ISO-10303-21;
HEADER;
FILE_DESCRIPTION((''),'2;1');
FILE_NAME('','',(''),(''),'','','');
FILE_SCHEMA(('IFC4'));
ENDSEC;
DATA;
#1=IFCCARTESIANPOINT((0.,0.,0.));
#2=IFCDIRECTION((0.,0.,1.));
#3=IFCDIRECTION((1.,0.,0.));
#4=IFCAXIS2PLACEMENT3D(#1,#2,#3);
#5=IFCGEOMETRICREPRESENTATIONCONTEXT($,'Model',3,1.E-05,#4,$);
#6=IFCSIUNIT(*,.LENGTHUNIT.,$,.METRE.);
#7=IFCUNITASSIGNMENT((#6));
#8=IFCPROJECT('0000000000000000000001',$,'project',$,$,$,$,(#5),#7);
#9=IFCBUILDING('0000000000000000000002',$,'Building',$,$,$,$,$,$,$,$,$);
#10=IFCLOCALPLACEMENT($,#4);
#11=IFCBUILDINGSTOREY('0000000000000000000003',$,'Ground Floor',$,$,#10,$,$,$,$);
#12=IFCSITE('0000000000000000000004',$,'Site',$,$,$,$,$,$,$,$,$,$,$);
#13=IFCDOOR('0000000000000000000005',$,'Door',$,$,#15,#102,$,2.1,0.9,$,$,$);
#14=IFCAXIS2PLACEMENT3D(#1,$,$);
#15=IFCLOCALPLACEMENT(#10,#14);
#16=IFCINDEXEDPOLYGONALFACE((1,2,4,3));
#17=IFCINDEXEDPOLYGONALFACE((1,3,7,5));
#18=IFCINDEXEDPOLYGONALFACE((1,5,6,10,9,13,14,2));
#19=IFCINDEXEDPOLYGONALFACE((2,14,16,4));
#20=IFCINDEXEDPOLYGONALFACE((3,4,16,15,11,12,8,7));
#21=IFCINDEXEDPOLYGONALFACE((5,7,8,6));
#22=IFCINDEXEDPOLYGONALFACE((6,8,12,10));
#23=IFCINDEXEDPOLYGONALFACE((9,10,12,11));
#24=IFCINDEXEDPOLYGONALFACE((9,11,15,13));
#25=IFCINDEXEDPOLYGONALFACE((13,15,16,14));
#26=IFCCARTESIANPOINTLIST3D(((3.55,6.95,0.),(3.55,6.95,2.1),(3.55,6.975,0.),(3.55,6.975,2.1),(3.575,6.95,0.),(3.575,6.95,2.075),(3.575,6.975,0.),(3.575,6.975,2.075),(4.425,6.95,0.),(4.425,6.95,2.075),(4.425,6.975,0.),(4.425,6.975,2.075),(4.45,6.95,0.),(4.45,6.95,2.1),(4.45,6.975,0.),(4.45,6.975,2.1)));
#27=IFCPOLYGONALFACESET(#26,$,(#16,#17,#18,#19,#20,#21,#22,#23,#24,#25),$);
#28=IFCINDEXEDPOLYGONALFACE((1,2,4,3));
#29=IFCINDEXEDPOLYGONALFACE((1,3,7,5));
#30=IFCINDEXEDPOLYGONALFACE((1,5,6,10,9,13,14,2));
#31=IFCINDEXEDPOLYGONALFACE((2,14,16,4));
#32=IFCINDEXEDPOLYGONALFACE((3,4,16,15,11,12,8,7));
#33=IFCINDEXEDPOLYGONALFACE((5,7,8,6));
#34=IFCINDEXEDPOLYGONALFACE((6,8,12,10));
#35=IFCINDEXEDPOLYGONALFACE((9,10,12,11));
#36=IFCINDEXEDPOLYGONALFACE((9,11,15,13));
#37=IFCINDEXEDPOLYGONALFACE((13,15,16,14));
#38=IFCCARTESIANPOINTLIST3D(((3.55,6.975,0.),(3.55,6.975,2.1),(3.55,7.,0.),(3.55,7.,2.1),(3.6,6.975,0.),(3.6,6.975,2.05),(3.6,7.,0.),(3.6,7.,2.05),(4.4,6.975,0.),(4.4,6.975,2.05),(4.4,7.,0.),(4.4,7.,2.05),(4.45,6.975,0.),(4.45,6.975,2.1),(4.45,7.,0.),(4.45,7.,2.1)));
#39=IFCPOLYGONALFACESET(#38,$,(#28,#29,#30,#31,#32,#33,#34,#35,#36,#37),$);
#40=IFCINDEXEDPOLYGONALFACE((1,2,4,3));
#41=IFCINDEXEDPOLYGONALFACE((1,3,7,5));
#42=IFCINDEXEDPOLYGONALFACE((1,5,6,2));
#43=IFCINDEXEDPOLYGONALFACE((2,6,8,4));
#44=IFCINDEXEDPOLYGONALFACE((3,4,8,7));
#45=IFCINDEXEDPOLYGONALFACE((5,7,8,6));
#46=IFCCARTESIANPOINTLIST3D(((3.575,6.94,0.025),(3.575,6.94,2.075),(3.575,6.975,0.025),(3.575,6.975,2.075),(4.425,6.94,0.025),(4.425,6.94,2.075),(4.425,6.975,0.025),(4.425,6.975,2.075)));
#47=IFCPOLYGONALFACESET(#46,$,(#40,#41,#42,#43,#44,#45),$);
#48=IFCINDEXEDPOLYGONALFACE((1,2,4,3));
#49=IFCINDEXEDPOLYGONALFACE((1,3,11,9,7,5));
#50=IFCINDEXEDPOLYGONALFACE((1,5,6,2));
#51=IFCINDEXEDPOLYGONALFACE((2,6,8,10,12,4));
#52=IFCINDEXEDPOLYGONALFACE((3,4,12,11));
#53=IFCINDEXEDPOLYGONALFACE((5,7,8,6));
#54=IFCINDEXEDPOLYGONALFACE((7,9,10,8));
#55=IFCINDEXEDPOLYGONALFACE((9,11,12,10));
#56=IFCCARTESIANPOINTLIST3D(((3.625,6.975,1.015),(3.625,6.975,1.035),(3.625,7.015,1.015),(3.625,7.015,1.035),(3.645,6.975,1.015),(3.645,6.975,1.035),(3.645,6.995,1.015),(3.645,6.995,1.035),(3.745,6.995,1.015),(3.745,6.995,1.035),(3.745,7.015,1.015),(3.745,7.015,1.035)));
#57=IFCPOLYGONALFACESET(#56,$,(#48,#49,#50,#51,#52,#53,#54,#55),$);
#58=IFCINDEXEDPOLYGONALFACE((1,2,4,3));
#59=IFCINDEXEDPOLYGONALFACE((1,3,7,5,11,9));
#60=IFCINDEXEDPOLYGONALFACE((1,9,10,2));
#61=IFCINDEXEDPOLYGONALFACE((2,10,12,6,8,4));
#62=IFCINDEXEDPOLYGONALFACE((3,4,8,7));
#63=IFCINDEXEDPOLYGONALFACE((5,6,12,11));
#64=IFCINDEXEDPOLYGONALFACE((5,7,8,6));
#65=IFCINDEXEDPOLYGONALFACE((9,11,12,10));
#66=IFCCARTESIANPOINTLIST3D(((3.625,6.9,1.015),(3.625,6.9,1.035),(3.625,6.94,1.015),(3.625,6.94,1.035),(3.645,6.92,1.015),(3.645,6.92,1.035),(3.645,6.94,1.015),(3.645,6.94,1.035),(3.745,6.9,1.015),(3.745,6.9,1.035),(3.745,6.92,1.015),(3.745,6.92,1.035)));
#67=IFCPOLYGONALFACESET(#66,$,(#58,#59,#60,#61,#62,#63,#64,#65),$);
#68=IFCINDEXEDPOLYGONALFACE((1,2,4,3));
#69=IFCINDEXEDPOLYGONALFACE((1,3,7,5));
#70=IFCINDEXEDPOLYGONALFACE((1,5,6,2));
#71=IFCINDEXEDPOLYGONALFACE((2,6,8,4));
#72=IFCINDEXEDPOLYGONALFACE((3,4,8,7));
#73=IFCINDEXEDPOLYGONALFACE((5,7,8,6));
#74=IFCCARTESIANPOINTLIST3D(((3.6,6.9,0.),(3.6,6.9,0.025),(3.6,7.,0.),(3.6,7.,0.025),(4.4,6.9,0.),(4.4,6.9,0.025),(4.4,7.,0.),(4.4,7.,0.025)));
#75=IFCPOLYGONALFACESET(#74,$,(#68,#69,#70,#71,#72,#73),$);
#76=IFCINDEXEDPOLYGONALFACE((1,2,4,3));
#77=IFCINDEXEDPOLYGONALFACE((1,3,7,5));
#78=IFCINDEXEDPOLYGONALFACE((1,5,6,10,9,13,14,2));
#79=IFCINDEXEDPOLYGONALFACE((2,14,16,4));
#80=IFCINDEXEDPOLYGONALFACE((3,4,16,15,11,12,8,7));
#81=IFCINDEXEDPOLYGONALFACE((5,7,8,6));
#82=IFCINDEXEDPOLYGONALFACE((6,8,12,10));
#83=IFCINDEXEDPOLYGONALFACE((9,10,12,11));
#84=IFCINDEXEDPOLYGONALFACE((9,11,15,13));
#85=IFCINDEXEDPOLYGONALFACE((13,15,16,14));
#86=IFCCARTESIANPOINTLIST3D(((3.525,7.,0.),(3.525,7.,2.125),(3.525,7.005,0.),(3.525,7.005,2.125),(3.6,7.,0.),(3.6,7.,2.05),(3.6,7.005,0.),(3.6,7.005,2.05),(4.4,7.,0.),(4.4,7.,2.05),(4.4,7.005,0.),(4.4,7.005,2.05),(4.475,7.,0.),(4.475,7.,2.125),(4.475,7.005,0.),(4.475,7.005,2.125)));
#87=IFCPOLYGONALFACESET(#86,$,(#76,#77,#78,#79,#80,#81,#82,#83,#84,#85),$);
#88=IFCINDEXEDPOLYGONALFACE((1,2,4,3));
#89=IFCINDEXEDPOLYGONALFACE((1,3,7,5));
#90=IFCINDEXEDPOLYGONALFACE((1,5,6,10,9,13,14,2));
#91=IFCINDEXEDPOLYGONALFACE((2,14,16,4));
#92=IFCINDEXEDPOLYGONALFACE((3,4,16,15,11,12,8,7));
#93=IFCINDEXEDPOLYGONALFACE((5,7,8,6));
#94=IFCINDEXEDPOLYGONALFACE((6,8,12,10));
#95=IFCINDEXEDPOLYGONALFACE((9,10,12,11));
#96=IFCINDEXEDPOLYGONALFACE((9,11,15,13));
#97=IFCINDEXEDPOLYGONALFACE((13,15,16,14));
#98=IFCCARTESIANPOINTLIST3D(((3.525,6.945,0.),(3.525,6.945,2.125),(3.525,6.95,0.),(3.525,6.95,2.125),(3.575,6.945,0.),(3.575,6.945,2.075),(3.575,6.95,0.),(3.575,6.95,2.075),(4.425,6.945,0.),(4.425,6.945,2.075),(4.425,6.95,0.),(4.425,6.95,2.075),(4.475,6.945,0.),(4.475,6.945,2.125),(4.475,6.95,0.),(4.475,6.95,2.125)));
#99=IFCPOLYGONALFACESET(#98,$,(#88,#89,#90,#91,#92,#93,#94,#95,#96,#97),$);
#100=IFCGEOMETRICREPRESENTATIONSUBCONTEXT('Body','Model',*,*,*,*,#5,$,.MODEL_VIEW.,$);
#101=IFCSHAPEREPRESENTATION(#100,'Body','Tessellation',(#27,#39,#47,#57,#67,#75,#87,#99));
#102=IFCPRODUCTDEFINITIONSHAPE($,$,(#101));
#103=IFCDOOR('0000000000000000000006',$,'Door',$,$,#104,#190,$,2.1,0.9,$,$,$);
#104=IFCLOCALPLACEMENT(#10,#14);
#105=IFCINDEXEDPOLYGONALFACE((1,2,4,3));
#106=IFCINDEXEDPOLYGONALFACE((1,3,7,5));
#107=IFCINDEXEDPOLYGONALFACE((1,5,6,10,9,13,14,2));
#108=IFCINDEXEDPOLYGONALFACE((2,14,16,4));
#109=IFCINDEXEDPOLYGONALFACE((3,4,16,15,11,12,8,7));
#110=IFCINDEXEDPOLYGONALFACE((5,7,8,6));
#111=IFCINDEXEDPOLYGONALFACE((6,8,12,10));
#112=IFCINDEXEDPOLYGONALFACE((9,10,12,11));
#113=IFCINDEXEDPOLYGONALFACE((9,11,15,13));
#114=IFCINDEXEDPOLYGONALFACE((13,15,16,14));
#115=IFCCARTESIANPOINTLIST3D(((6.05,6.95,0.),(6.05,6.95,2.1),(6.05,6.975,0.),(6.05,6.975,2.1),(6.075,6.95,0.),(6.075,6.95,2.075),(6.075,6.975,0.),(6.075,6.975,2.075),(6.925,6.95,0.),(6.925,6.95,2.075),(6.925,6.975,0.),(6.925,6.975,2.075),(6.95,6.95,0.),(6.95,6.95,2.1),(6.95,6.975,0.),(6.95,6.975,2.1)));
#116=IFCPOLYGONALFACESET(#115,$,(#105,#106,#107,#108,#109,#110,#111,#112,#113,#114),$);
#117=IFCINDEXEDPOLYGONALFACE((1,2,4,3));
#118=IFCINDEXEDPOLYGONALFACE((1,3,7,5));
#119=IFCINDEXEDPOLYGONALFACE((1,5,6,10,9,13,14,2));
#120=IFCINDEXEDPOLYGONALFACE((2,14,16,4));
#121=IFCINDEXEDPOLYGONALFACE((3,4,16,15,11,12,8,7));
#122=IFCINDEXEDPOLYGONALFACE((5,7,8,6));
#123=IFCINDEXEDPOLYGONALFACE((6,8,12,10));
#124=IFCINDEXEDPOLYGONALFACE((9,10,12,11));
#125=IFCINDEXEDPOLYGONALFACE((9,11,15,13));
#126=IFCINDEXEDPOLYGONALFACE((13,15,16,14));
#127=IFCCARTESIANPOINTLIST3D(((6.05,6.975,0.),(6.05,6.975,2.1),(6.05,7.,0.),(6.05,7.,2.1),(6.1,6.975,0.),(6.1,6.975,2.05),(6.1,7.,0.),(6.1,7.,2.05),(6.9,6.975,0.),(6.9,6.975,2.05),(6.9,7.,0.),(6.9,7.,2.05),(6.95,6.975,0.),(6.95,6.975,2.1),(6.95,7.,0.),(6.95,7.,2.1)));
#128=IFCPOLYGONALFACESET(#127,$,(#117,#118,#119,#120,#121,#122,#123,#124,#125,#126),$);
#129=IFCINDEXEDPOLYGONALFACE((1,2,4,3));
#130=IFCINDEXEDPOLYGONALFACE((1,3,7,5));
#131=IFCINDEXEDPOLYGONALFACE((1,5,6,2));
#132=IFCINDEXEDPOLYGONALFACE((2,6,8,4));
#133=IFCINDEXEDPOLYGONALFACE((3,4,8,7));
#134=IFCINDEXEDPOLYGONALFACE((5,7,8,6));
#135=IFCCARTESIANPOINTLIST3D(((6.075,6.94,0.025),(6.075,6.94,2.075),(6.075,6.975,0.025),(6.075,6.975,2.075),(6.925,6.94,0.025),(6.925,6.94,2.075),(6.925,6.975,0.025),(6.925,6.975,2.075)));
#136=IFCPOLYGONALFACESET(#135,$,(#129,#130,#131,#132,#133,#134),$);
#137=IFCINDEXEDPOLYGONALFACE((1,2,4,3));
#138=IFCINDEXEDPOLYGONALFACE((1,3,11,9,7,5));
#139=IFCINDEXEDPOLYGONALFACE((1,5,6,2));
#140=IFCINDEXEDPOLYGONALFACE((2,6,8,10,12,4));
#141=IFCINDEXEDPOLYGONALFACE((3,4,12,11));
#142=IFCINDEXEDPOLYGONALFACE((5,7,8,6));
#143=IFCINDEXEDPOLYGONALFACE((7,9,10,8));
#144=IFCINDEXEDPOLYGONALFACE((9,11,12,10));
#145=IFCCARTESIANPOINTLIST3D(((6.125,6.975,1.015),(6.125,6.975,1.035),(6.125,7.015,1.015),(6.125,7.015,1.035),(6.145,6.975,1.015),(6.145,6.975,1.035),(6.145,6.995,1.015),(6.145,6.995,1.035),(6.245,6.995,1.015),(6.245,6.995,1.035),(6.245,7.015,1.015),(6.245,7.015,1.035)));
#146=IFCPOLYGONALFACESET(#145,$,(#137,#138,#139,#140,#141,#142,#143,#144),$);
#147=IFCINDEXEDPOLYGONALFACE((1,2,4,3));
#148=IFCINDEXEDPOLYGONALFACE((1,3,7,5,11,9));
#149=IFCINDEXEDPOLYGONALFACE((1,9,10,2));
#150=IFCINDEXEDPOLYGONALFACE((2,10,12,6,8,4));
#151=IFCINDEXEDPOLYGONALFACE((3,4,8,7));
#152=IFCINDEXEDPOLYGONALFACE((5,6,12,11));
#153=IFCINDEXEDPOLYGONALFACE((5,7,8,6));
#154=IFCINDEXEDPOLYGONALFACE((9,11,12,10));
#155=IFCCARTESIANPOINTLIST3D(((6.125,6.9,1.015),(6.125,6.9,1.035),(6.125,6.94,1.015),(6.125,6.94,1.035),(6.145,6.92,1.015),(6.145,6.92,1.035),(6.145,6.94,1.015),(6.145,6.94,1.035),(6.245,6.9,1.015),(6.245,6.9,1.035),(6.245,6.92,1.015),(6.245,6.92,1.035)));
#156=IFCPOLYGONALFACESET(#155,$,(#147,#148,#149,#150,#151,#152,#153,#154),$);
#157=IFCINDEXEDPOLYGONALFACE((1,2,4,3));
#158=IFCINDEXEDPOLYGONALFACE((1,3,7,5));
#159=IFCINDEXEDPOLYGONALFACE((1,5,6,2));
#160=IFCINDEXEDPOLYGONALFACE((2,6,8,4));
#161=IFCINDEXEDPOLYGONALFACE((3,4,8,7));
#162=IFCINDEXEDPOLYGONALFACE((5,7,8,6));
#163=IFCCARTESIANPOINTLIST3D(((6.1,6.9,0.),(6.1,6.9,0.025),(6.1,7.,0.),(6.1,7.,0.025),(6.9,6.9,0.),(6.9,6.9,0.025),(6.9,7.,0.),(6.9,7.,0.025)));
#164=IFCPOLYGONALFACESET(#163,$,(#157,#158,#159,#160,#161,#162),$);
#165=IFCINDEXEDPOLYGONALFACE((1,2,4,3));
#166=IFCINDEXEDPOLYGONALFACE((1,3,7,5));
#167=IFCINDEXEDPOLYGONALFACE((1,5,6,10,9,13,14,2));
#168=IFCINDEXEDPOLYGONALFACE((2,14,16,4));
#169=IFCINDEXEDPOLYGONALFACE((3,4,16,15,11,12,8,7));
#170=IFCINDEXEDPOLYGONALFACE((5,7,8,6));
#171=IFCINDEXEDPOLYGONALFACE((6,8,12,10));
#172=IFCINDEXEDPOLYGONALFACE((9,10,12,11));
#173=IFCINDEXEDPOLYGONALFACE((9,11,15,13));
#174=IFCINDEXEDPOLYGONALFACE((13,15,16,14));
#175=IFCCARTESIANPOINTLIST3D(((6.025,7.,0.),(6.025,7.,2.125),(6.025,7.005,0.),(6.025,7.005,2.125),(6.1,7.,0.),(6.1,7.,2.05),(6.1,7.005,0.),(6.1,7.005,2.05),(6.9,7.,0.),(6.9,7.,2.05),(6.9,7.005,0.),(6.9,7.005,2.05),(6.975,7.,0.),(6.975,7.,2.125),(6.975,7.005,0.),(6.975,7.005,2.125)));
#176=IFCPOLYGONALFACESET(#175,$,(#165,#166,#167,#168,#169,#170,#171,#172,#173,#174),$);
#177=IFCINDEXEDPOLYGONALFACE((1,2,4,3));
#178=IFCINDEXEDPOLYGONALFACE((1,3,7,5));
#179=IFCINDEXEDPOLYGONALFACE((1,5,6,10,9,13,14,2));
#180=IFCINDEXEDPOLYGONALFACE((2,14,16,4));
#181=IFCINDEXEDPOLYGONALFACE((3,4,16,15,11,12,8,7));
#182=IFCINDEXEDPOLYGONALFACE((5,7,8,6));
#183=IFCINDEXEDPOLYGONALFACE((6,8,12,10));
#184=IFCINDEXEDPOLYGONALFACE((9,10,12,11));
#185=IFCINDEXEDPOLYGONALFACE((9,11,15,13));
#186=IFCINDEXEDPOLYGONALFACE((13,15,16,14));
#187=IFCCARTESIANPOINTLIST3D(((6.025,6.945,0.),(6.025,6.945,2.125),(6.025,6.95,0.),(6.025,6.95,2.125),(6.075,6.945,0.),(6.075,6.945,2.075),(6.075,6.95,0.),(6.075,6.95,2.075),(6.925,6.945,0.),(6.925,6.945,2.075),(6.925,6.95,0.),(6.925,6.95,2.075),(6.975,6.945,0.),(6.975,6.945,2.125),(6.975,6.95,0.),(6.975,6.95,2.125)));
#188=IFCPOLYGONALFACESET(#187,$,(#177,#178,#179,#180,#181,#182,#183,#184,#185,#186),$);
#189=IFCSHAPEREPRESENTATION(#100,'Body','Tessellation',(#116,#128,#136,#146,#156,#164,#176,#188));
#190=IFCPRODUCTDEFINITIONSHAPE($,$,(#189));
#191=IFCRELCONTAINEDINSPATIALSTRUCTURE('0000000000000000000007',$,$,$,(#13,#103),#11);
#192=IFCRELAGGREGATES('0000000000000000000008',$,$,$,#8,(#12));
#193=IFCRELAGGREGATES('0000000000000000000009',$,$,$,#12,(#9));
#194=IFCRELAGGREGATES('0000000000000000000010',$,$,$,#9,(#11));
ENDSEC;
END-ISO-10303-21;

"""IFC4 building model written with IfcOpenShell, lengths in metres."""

from ifc_helpers import new_model, si_unit, frame, origin_with_axes, place, context, subcontext, project, spatial, line, indexed_curve, outline, extrude, element, save


model = new_model("IFC4")

# Units and contexts
model_context = context("Model", 3, precision=1e-05, world=origin_with_axes())
body_context = subcontext(model_context, "Body", "Model", "MODEL_VIEW")
ifc_project = project(units=[si_unit("LENGTHUNIT", "METRE")], contexts=[model_context])

# Site, building, storey
site = spatial("IfcSite", under=ifc_project, Name="Site")
building = spatial("IfcBuilding", under=site, Name="Building")
storey_placement = place(None, origin_with_axes())
storey = spatial("IfcBuildingStorey", under=building, at=storey_placement, Name="Ground Floor")

# Doors
door_1_placement = place(storey_placement, frame((4.45, 7.0, 0.0), z_axis=(0.0, 0.0, 1.0), x_axis=(-1.0, 0.0, 0.0)))
element("IfcDoor", 1, at=door_1_placement, inside=storey, Name="Door", OverallHeight=2.1, OverallWidth=0.9, context=body_context, shape_type="SweptSolid", body=[
    extrude(outline(indexed_curve([(0.0, 0.0), (0.0, 2.1), (0.9, 2.1), (0.9, 0.0), (0.875, 0.0), (0.875, 2.075), (0.025, 2.075), (0.025, 0.0)], segments=[line(1, 2, 3, 4, 5, 6, 7, 8, 1)])), frame((0.0, 0.025, 0.0), z_axis=(0.0, -1.0, 0.0), x_axis=(1.0, 0.0, 0.0)), (0.0, 0.0, -1.0), 0.025),
    extrude(outline(indexed_curve([(0.0, 0.0), (0.0, 2.1), (0.9, 2.1), (0.9, 0.0), (0.85, 0.0), (0.85, 2.05), (0.05, 2.05), (0.05, 0.0)], segments=[line(1, 2, 3, 4, 5, 6, 7, 8, 1)])), frame((0.0, 0.0, 0.0), z_axis=(0.0, -1.0, 0.0), x_axis=(1.0, 0.0, 0.0)), (0.0, 0.0, -1.0), 0.025),
    extrude(outline(indexed_curve([(0.0, 0.0), (0.85, 0.0), (0.85, 0.035), (0.0, 0.035)], segments=[line(1, 2, 3, 4, 1)])), frame((0.025, 0.025, 0.025), z_axis=(0.0, 0.0, 1.0), x_axis=(1.0, 0.0, 0.0)), (0.0, 0.0, 1.0), 2.05),
    extrude(outline(indexed_curve([(0.0, 0.0), (0.0, -0.04), (-0.12, -0.04), (-0.12, -0.02), (-0.02, -0.02), (-0.02, 0.0)], segments=[line(1, 2, 3, 4, 5, 6, 1)])), frame((0.825, 0.025, 1.015), z_axis=(0.0, 0.0, 1.0), x_axis=(1.0, 0.0, 0.0)), (0.0, 0.0, 1.0), 0.02),
    extrude(outline(indexed_curve([(0.0, 0.0), (0.0, 0.04), (-0.12, 0.04), (-0.12, 0.02), (-0.02, 0.02), (-0.02, 0.0)], segments=[line(1, 2, 3, 4, 5, 6, 1)])), frame((0.825, 0.06, 1.015), z_axis=(0.0, 0.0, 1.0), x_axis=(1.0, 0.0, 0.0)), (0.0, 0.0, 1.0), 0.02),
    extrude(outline(indexed_curve([(0.0, 0.0), (0.8, 0.0), (0.8, 0.1), (0.0, 0.1)], segments=[line(1, 2, 3, 4, 1)])), frame((0.05, 0.0, 0.0), z_axis=(0.0, 0.0, 1.0), x_axis=(1.0, 0.0, 0.0)), (0.0, 0.0, 1.0), 0.025),
    extrude(outline(indexed_curve([(0.0, 0.0), (0.0, 2.125), (0.95, 2.125), (0.95, 0.0), (0.875, 0.0), (0.875, 2.05), (0.075, 2.05), (0.075, 0.0)], segments=[line(1, 2, 3, 4, 5, 6, 7, 8, 1)])), frame((-0.025, -0.005, 0.0), z_axis=(0.0, -1.0, 0.0), x_axis=(1.0, 0.0, 0.0)), (0.0, 0.0, -1.0), 0.005),
    extrude(outline(indexed_curve([(0.0, 0.0), (0.0, 2.125), (0.95, 2.125), (0.95, 0.0), (0.9, 0.0), (0.9, 2.075), (0.05, 2.075), (0.05, 0.0)], segments=[line(1, 2, 3, 4, 5, 6, 7, 8, 1)])), frame((-0.025, 0.05, 0.0), z_axis=(0.0, -1.0, 0.0), x_axis=(1.0, 0.0, 0.0)), (0.0, 0.0, -1.0), 0.005),
])
door_2_placement = place(storey_placement, frame((6.95, 7.0, 0.0), z_axis=(0.0, 0.0, 1.0), x_axis=(-1.0, 0.0, 0.0)))
element("IfcDoor", 2, at=door_2_placement, inside=storey, Name="Door", OverallHeight=2.1, OverallWidth=0.9, context=body_context, shape_type="SweptSolid", body=[
    extrude(outline(indexed_curve([(0.0, 0.0), (0.0, 2.1), (0.9, 2.1), (0.9, 0.0), (0.875, 0.0), (0.875, 2.075), (0.025, 2.075), (0.025, 0.0)], segments=[line(1, 2, 3, 4, 5, 6, 7, 8, 1)])), frame((0.0, 0.025, 0.0), z_axis=(0.0, -1.0, 0.0), x_axis=(1.0, 0.0, 0.0)), (0.0, 0.0, -1.0), 0.025),
    extrude(outline(indexed_curve([(0.0, 0.0), (0.0, 2.1), (0.9, 2.1), (0.9, 0.0), (0.85, 0.0), (0.85, 2.05), (0.05, 2.05), (0.05, 0.0)], segments=[line(1, 2, 3, 4, 5, 6, 7, 8, 1)])), frame((0.0, 0.0, 0.0), z_axis=(0.0, -1.0, 0.0), x_axis=(1.0, 0.0, 0.0)), (0.0, 0.0, -1.0), 0.025),
    extrude(outline(indexed_curve([(0.0, 0.0), (0.85, 0.0), (0.85, 0.035), (0.0, 0.035)], segments=[line(1, 2, 3, 4, 1)])), frame((0.025, 0.025, 0.025), z_axis=(0.0, 0.0, 1.0), x_axis=(1.0, 0.0, 0.0)), (0.0, 0.0, 1.0), 2.05),
    extrude(outline(indexed_curve([(0.0, 0.0), (0.0, -0.04), (-0.12, -0.04), (-0.12, -0.02), (-0.02, -0.02), (-0.02, 0.0)], segments=[line(1, 2, 3, 4, 5, 6, 1)])), frame((0.825, 0.025, 1.015), z_axis=(0.0, 0.0, 1.0), x_axis=(1.0, 0.0, 0.0)), (0.0, 0.0, 1.0), 0.02),
    extrude(outline(indexed_curve([(0.0, 0.0), (0.0, 0.04), (-0.12, 0.04), (-0.12, 0.02), (-0.02, 0.02), (-0.02, 0.0)], segments=[line(1, 2, 3, 4, 5, 6, 1)])), frame((0.825, 0.06, 1.015), z_axis=(0.0, 0.0, 1.0), x_axis=(1.0, 0.0, 0.0)), (0.0, 0.0, 1.0), 0.02),
    extrude(outline(indexed_curve([(0.0, 0.0), (0.8, 0.0), (0.8, 0.1), (0.0, 0.1)], segments=[line(1, 2, 3, 4, 1)])), frame((0.05, 0.0, 0.0), z_axis=(0.0, 0.0, 1.0), x_axis=(1.0, 0.0, 0.0)), (0.0, 0.0, 1.0), 0.025),
    extrude(outline(indexed_curve([(0.0, 0.0), (0.0, 2.125), (0.95, 2.125), (0.95, 0.0), (0.875, 0.0), (0.875, 2.05), (0.075, 2.05), (0.075, 0.0)], segments=[line(1, 2, 3, 4, 5, 6, 7, 8, 1)])), frame((-0.025, -0.005, 0.0), z_axis=(0.0, -1.0, 0.0), x_axis=(1.0, 0.0, 0.0)), (0.0, 0.0, -1.0), 0.005),
    extrude(outline(indexed_curve([(0.0, 0.0), (0.0, 2.125), (0.95, 2.125), (0.95, 0.0), (0.9, 0.0), (0.9, 2.075), (0.05, 2.075), (0.05, 0.0)], segments=[line(1, 2, 3, 4, 5, 6, 7, 8, 1)])), frame((-0.025, 0.05, 0.0), z_axis=(0.0, -1.0, 0.0), x_axis=(1.0, 0.0, 0.0)), (0.0, 0.0, -1.0), 0.005),
])

save(model, "model.ifc")
